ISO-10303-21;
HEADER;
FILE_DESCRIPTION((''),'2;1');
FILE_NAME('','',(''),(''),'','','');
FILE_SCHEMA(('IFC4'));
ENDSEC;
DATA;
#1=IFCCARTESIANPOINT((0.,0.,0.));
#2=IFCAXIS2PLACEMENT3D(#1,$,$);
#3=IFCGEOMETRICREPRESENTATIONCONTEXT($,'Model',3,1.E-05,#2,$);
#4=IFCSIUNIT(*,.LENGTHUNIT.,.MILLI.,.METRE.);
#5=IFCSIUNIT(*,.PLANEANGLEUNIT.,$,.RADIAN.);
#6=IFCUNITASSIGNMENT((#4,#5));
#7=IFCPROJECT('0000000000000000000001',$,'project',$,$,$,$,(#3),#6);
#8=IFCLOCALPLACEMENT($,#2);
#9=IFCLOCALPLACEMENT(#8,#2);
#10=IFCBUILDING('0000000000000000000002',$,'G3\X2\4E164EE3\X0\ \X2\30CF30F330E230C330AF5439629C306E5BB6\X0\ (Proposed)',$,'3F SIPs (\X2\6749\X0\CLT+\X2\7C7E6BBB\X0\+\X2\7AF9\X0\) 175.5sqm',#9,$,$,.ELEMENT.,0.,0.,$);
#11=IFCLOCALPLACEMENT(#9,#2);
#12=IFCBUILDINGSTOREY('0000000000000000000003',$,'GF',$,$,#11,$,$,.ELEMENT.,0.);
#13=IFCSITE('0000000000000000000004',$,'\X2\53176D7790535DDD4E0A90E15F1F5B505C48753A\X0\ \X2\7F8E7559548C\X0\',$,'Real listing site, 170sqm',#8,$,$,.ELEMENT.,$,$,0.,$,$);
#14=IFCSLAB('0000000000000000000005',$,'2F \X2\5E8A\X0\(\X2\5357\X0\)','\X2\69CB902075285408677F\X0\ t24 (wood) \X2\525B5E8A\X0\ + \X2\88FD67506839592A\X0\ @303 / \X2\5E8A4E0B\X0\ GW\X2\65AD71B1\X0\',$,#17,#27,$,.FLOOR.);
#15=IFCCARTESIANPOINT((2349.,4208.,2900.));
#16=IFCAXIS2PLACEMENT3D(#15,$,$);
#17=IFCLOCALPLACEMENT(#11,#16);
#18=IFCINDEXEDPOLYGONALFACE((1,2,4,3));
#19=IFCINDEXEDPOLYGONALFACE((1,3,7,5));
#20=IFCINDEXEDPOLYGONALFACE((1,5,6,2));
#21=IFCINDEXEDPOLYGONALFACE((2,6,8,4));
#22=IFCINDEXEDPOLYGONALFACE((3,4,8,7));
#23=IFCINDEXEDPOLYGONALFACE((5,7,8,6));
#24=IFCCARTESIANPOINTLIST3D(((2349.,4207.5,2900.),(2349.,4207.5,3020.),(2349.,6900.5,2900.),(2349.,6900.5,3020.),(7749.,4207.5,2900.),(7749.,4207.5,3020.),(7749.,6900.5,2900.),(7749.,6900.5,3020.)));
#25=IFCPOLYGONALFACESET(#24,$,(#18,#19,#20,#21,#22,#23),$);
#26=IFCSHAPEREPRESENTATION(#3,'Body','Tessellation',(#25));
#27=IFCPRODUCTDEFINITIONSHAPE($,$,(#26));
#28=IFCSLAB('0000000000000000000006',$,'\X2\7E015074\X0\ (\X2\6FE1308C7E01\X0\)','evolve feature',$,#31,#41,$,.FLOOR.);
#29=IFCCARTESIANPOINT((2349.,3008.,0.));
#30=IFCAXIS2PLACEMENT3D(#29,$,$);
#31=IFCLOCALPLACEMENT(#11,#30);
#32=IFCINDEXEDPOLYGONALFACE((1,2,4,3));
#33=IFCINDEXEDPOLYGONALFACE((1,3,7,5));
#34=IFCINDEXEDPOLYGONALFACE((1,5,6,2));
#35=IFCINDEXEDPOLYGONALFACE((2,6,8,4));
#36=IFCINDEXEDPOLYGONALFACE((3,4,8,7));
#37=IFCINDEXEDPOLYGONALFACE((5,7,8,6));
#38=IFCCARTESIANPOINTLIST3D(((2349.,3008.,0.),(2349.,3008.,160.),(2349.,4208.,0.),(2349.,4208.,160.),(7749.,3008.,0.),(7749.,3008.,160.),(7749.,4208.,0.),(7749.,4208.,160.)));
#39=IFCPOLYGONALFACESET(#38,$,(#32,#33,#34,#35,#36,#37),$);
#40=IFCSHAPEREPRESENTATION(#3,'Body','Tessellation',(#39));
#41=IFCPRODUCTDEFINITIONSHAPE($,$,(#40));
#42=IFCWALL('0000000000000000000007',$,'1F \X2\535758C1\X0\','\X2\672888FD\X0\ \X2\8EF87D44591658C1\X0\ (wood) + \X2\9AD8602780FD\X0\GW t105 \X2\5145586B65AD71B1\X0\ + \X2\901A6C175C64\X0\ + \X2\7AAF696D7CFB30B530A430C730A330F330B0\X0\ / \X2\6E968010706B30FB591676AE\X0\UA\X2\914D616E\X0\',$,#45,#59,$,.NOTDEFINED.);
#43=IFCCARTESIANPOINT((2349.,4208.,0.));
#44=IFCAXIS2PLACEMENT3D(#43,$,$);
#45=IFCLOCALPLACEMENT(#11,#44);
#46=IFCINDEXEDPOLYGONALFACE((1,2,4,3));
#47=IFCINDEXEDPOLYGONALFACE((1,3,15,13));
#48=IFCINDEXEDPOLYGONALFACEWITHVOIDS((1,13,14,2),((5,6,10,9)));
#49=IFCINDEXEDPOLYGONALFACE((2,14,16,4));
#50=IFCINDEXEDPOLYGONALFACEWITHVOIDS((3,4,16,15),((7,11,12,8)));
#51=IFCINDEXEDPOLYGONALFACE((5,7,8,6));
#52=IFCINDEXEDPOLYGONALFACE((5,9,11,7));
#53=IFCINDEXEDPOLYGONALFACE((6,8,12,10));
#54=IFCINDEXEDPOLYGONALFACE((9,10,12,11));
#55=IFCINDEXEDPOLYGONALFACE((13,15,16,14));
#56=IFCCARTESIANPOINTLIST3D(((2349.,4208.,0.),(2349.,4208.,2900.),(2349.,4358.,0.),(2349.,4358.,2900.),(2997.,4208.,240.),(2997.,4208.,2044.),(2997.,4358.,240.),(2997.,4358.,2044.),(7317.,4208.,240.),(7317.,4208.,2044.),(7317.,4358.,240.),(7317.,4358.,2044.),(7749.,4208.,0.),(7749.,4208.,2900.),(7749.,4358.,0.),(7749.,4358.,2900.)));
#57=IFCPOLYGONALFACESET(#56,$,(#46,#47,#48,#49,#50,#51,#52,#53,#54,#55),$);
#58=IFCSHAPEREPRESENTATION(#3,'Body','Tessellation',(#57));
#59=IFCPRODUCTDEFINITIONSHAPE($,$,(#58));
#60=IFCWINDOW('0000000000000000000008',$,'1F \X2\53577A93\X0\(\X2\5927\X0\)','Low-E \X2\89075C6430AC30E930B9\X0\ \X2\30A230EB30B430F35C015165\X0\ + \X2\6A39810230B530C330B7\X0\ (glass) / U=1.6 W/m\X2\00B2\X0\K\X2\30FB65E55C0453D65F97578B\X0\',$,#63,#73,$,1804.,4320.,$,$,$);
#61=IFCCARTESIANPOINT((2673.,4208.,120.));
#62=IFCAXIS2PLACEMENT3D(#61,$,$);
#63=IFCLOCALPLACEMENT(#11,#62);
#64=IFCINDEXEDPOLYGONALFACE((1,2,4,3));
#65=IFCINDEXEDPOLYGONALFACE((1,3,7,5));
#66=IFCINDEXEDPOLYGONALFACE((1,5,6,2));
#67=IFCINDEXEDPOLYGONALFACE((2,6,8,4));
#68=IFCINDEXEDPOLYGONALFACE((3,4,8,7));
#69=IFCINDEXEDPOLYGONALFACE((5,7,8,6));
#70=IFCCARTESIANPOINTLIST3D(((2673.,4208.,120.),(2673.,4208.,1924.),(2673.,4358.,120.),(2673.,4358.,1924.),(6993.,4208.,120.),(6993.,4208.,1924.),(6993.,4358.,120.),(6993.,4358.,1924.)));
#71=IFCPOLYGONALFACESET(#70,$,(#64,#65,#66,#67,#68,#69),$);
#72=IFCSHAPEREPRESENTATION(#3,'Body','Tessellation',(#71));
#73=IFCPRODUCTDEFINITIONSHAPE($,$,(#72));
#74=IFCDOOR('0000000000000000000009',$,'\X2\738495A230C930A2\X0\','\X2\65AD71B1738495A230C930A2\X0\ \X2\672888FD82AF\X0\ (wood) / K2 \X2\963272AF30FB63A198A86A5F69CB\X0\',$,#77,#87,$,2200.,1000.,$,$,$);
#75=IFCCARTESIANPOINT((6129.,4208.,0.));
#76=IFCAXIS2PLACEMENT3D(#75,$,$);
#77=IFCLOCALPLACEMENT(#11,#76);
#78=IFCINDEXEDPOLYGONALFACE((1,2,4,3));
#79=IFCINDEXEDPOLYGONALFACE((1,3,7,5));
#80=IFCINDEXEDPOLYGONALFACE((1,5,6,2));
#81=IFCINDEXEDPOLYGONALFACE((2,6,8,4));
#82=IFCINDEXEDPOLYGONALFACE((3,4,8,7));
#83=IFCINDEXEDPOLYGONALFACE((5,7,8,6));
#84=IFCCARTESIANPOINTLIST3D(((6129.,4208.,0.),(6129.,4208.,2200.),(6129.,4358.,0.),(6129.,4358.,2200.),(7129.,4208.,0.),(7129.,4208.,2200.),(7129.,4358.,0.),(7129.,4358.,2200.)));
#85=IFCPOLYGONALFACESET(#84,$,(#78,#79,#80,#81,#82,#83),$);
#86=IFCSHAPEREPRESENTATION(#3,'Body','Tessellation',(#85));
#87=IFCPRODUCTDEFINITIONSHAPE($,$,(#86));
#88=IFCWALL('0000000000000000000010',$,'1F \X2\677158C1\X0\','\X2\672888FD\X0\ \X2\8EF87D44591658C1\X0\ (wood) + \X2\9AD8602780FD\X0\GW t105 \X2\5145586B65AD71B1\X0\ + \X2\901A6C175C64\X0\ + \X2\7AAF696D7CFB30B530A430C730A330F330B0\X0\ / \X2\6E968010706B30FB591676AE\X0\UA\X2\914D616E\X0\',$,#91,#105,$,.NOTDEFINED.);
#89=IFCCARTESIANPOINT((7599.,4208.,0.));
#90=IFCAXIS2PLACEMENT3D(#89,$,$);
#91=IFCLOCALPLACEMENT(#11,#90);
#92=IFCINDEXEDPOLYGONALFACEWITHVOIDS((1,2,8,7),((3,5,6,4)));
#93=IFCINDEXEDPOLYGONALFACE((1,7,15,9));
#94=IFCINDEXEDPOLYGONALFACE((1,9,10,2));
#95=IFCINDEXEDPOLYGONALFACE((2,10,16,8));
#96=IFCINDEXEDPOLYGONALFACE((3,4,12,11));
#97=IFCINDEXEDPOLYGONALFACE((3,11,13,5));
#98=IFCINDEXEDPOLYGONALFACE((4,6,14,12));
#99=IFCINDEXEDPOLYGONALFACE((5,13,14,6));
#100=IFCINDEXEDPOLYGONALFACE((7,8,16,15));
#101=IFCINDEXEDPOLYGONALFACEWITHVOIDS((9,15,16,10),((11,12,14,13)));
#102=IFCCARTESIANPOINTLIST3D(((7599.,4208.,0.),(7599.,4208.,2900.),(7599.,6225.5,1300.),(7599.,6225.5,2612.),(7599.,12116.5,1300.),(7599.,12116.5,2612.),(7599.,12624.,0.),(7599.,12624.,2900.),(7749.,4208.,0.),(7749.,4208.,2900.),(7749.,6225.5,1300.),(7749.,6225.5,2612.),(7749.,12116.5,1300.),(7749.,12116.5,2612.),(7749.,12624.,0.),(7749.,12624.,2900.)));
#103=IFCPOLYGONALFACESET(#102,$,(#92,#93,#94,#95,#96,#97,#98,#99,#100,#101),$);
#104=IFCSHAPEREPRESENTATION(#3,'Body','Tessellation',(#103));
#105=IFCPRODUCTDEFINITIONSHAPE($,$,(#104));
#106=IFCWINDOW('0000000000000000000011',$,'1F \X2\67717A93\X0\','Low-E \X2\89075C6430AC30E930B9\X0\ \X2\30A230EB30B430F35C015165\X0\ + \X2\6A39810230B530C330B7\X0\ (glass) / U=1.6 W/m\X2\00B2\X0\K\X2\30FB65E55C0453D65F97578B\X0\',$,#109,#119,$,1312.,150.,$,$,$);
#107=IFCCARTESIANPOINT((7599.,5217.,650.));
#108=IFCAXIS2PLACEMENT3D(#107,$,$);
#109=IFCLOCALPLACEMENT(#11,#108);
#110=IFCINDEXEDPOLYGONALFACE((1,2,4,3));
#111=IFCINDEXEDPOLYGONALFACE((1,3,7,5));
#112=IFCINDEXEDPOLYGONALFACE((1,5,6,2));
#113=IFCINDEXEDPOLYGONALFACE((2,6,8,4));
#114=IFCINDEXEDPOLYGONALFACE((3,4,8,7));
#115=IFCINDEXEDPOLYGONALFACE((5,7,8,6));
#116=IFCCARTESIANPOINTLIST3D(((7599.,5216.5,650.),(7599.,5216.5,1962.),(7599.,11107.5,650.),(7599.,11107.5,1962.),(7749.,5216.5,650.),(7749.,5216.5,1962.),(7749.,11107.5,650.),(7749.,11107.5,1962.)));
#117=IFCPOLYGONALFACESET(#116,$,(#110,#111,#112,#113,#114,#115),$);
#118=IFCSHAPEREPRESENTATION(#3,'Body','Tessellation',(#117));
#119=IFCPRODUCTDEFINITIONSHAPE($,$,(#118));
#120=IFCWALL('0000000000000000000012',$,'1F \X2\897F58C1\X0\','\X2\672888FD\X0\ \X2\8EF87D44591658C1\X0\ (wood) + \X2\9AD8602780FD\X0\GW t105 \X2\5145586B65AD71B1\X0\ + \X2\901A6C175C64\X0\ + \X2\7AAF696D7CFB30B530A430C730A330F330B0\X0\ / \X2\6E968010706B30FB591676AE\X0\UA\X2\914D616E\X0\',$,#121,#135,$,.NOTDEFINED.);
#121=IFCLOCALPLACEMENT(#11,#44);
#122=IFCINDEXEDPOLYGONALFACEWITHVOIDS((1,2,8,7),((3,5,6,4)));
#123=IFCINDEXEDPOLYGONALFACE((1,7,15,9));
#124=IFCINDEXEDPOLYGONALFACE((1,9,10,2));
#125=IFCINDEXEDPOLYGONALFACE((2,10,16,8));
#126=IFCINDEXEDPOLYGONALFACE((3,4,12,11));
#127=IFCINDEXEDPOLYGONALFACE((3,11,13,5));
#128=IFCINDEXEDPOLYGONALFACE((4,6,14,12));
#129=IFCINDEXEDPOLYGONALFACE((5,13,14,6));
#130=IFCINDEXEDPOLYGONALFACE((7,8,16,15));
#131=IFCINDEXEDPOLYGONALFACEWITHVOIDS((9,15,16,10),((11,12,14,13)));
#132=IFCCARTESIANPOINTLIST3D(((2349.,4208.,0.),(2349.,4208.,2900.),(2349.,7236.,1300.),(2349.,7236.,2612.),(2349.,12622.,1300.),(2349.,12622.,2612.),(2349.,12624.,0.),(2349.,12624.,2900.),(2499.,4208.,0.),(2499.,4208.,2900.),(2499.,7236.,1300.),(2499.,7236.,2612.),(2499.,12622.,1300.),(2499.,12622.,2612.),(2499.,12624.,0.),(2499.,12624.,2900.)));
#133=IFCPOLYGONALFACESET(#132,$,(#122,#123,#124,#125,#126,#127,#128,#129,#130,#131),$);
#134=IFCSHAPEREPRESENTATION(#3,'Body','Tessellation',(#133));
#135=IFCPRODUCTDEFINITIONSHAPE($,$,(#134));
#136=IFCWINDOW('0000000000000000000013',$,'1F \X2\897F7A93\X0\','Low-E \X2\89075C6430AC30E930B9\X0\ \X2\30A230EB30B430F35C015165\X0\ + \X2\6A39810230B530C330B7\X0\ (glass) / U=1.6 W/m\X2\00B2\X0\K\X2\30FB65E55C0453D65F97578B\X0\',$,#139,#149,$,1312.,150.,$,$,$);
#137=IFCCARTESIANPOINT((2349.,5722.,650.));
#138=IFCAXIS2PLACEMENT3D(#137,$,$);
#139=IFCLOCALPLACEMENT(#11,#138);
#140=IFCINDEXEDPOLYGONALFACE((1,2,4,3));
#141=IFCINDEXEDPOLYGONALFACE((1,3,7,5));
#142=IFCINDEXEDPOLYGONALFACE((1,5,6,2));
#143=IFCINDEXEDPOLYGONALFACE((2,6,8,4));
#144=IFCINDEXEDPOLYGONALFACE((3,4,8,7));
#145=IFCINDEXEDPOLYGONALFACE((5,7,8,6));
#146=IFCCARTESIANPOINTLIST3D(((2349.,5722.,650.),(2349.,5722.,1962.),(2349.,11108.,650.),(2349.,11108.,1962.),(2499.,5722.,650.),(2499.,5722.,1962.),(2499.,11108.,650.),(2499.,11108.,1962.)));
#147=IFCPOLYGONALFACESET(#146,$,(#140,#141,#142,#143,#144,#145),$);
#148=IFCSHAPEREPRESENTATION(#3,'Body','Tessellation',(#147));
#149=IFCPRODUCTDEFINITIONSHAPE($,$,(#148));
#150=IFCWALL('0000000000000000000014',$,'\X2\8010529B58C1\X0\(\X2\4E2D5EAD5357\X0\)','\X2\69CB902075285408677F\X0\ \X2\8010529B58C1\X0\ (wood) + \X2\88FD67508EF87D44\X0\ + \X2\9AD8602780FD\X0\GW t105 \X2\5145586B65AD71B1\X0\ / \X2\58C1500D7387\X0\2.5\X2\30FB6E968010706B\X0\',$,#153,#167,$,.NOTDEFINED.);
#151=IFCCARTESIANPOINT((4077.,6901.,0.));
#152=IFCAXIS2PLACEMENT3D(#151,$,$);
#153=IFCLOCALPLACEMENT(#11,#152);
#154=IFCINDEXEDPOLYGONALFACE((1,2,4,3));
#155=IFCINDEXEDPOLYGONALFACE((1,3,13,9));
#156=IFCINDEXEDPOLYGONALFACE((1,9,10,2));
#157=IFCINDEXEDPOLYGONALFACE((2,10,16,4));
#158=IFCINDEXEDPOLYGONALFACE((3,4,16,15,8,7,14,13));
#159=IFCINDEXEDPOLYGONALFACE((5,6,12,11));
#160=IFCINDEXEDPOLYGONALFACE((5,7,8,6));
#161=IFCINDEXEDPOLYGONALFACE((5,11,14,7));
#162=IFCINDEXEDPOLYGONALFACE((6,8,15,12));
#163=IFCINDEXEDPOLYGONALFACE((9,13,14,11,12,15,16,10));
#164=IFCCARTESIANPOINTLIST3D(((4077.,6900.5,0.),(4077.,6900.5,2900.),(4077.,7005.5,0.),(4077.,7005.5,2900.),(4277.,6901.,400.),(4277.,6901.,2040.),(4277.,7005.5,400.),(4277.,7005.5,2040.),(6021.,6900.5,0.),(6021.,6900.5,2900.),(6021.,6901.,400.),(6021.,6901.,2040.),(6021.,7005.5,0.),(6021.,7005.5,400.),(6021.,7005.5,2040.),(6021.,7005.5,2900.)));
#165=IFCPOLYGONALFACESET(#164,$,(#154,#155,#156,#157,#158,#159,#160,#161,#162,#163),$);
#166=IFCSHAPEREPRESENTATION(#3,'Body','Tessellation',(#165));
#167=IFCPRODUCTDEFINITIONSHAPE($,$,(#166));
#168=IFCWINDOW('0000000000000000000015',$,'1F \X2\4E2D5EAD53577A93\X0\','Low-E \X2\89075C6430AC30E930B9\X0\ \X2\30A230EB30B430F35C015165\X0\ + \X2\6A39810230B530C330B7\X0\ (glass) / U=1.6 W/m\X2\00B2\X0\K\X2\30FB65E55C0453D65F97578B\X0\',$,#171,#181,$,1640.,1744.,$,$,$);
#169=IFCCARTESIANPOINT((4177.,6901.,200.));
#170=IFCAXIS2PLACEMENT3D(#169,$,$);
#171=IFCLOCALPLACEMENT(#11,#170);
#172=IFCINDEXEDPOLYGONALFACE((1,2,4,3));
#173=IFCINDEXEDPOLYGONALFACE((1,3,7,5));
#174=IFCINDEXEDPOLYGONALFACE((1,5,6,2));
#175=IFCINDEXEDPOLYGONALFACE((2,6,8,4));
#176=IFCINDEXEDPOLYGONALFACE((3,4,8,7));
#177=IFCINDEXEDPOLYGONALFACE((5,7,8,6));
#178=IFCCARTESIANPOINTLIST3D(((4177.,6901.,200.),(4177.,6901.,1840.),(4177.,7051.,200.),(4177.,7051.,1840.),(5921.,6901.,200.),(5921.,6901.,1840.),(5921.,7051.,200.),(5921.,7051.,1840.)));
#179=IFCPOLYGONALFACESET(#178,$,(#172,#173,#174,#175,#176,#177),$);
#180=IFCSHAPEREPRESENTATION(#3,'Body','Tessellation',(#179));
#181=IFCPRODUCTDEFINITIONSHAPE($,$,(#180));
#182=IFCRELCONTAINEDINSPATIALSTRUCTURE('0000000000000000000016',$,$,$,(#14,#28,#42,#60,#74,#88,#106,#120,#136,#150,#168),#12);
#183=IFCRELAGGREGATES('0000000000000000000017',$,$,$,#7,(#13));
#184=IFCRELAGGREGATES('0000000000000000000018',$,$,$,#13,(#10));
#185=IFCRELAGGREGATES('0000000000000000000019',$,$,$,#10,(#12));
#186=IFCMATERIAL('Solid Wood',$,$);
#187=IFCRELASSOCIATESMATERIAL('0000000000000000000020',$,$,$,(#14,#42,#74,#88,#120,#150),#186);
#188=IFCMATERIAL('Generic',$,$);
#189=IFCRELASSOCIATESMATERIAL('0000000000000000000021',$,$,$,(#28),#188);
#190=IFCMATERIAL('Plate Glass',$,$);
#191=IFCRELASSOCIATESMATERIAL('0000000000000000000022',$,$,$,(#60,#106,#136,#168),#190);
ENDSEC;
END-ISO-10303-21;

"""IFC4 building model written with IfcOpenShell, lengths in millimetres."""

from ifc_helpers import new_model, si_unit, frame, frame_2d, origin, place, context, project, spatial, rectangle, extrude, material, element, fill, save


model = new_model("IFC4")

# Units and contexts
model_context = context("Model", 3, precision=1e-05, world=origin())
ifc_project = project(units=[si_unit("LENGTHUNIT", "METRE", prefix="MILLI"), si_unit("PLANEANGLEUNIT", "RADIAN")], contexts=[model_context])

# Site, building, storey
site_placement = place(None, origin())
site = spatial("IfcSite", under=ifc_project, at=site_placement, Name="北海道川上郡弟子屈町 美留和", ObjectType="Real listing site, 170sqm", CompositionType="ELEMENT", RefElevation=0.0)
building_placement = place(site_placement, origin())
building = spatial("IfcBuilding", under=site, at=building_placement, Name="G3世代 ハンモック吹抜の家 (Proposed)", ObjectType="3F SIPs (杉CLT+籾殻+竹) 175.5sqm", CompositionType="ELEMENT", ElevationOfRefHeight=0.0, ElevationOfTerrain=0.0)
storey_placement = place(building_placement, origin())
storey = spatial("IfcBuildingStorey", under=building, at=storey_placement, Name="GF", CompositionType="ELEMENT", Elevation=0.0)

# Slabs
ifc_material_1 = material(Name="Solid Wood")
slab_1_placement = place(storey_placement, frame((2349.0, 4208.0, 2900.0)))
element("IfcSlab", 1, at=slab_1_placement, inside=storey, material=ifc_material_1, Name="2F 床(南)", Description="構造用合板 t24 (wood) 剛床 + 製材根太 @303 / 床下 GW断熱", PredefinedType="FLOOR", context=model_context, shape_type="SweptSolid", body=[
    extrude(rectangle(XDim=5400.0, YDim=2693.0, at=frame_2d((2700.0, 1346.0))), frame((2349.0, 4208.0, 2900.0)), (0.0, 0.0, 1.0), 120.0),
])
ifc_material_2 = material(Name="Generic")
slab_2_placement = place(storey_placement, frame((2349.0, 3008.0, 0.0)))
element("IfcSlab", 2, at=slab_2_placement, inside=storey, material=ifc_material_2, Name="縁側 (濡れ縁)", Description="evolve feature", PredefinedType="FLOOR", context=model_context, shape_type="SweptSolid", body=[
    extrude(rectangle(XDim=5400.0, YDim=1200.0, at=frame_2d((2700.0, 600.0))), frame((2349.0, 3008.0, 0.0)), (0.0, 0.0, 1.0), 160.0),
])

# Wall, openings, window, door
wall_1_placement = place(storey_placement, frame((2349.0, 4208.0, 0.0)))
wall_1 = element("IfcWall", 3, at=wall_1_placement, inside=storey, material=ifc_material_1, Name="1F 南壁", Description="木製 軸組外壁 (wood) + 高性能GW t105 充填断熱 + 通気層 + 窯業系サイディング / 準耐火・外皮UA配慮", PredefinedType="NOTDEFINED", context=model_context, shape_type="SweptSolid", body=[
    extrude(rectangle(XDim=5400.0, YDim=150.0, at=frame_2d((2700.0, 75.0))), frame((2349.0, 4208.0, 0.0)), (0.0, 0.0, 1.0), 2900.0),
])
opening_1_placement = place(storey_placement, frame((2673.0, 4208.0, 120.0)))
opening_1 = element("IfcOpeningElement", 4, at=opening_1_placement, cuts=wall_1, PredefinedType="NOTDEFINED", context=model_context, shape_type="SweptSolid", body=[
    extrude(rectangle(XDim=4320.0, YDim=150.0, at=frame_2d((2160.0, 75.0))), frame((2673.0, 4208.0, 120.0)), (0.0, 0.0, 1.0), 1804.0),
])
opening_2_placement = place(storey_placement, frame((6129.0, 4208.0, 0.0)))
opening_2 = element("IfcOpeningElement", 5, at=opening_2_placement, cuts=wall_1, PredefinedType="NOTDEFINED", context=model_context, shape_type="SweptSolid", body=[
    extrude(rectangle(XDim=1000.0, YDim=150.0, at=frame_2d((500.0, 75.0))), frame((6129.0, 4208.0, 0.0)), (0.0, 0.0, 1.0), 2200.0),
])
ifc_material_3 = material(Name="Plate Glass")
window_1_placement = place(storey_placement, frame((2673.0, 4208.0, 120.0)))
window_1 = element("IfcWindow", 6, at=window_1_placement, inside=storey, material=ifc_material_3, Name="1F 南窓(大)", Description="Low-E 複層ガラス アルゴン封入 + 樹脂サッシ (glass) / U=1.6 W/m²K・日射取得型", OverallHeight=1804.0, OverallWidth=4320.0, context=model_context, shape_type="SweptSolid", body=[
    extrude(rectangle(XDim=4320.0, YDim=150.0, at=frame_2d((2160.0, 75.0))), frame((2673.0, 4208.0, 120.0)), (0.0, 0.0, 1.0), 1804.0),
])
fill(opening_1, window_1)
door_placement = place(storey_placement, frame((6129.0, 4208.0, 0.0)))
door = element("IfcDoor", 7, at=door_placement, inside=storey, material=ifc_material_1, Name="玄関ドア", Description="断熱玄関ドア 木製芯 (wood) / K2 防犯・採風機構", OverallHeight=2200.0, OverallWidth=1000.0, context=model_context, shape_type="SweptSolid", body=[
    extrude(rectangle(XDim=1000.0, YDim=150.0, at=frame_2d((500.0, 75.0))), frame((6129.0, 4208.0, 0.0)), (0.0, 0.0, 1.0), 2200.0),
])
fill(opening_2, door)

# Walls, openings, windows
wall_2_placement = place(storey_placement, frame((7599.0, 4208.0, 0.0)))
wall_2 = element("IfcWall", 8, at=wall_2_placement, inside=storey, material=ifc_material_1, Name="1F 東壁", Description="木製 軸組外壁 (wood) + 高性能GW t105 充填断熱 + 通気層 + 窯業系サイディング / 準耐火・外皮UA配慮", PredefinedType="NOTDEFINED", context=model_context, shape_type="SweptSolid", body=[
    extrude(rectangle(XDim=150.0, YDim=8416.0, at=frame_2d((75.0, 4208.0))), frame((7599.0, 4208.0, 0.0)), (0.0, 0.0, 1.0), 2900.0),
])
opening_3_placement = place(storey_placement, frame((7599.0, 5217.0, 650.0)))
opening_3 = element("IfcOpeningElement", 9, at=opening_3_placement, cuts=wall_2, PredefinedType="NOTDEFINED", context=model_context, shape_type="SweptSolid", body=[
    extrude(rectangle(XDim=150.0, YDim=5891.0, at=frame_2d((75.0, 2945.0))), frame((7599.0, 5217.0, 650.0)), (0.0, 0.0, 1.0), 1312.0),
])
window_2_placement = place(storey_placement, frame((7599.0, 5217.0, 650.0)))
window_2 = element("IfcWindow", 10, at=window_2_placement, inside=storey, material=ifc_material_3, Name="1F 東窓", Description="Low-E 複層ガラス アルゴン封入 + 樹脂サッシ (glass) / U=1.6 W/m²K・日射取得型", OverallHeight=1312.0, OverallWidth=150.0, context=model_context, shape_type="SweptSolid", body=[
    extrude(rectangle(XDim=150.0, YDim=5891.0, at=frame_2d((75.0, 2945.0))), frame((7599.0, 5217.0, 650.0)), (0.0, 0.0, 1.0), 1312.0),
])
fill(opening_3, window_2)
wall_3_placement = place(storey_placement, frame((2349.0, 4208.0, 0.0)))
wall_3 = element("IfcWall", 11, at=wall_3_placement, inside=storey, material=ifc_material_1, Name="1F 西壁", Description="木製 軸組外壁 (wood) + 高性能GW t105 充填断熱 + 通気層 + 窯業系サイディング / 準耐火・外皮UA配慮", PredefinedType="NOTDEFINED", context=model_context, shape_type="SweptSolid", body=[
    extrude(rectangle(XDim=150.0, YDim=8416.0, at=frame_2d((75.0, 4208.0))), frame((2349.0, 4208.0, 0.0)), (0.0, 0.0, 1.0), 2900.0),
])
opening_4_placement = place(storey_placement, frame((2349.0, 5722.0, 650.0)))
opening_4 = element("IfcOpeningElement", 12, at=opening_4_placement, cuts=wall_3, PredefinedType="NOTDEFINED", context=model_context, shape_type="SweptSolid", body=[
    extrude(rectangle(XDim=150.0, YDim=5386.0, at=frame_2d((75.0, 2693.0))), frame((2349.0, 5722.0, 650.0)), (0.0, 0.0, 1.0), 1312.0),
])
window_3_placement = place(storey_placement, frame((2349.0, 5722.0, 650.0)))
window_3 = element("IfcWindow", 13, at=window_3_placement, inside=storey, material=ifc_material_3, Name="1F 西窓", Description="Low-E 複層ガラス アルゴン封入 + 樹脂サッシ (glass) / U=1.6 W/m²K・日射取得型", OverallHeight=1312.0, OverallWidth=150.0, context=model_context, shape_type="SweptSolid", body=[
    extrude(rectangle(XDim=150.0, YDim=5386.0, at=frame_2d((75.0, 2693.0))), frame((2349.0, 5722.0, 650.0)), (0.0, 0.0, 1.0), 1312.0),
])
fill(opening_4, window_3)
wall_4_placement = place(storey_placement, frame((4077.0, 6901.0, 0.0)))
wall_4 = element("IfcWall", 14, at=wall_4_placement, inside=storey, material=ifc_material_1, Name="耐力壁(中庭南)", Description="構造用合板 耐力壁 (wood) + 製材軸組 + 高性能GW t105 充填断熱 / 壁倍率2.5・準耐火", PredefinedType="NOTDEFINED", context=model_context, shape_type="SweptSolid", body=[
    extrude(rectangle(XDim=1944.0, YDim=105.0, at=frame_2d((972.0, 52.0))), frame((4077.0, 6901.0, 0.0)), (0.0, 0.0, 1.0), 2900.0),
])
opening_5_placement = place(storey_placement, frame((4177.0, 6901.0, 200.0)))
opening_5 = element("IfcOpeningElement", 15, at=opening_5_placement, cuts=wall_4, PredefinedType="NOTDEFINED", context=model_context, shape_type="SweptSolid", body=[
    extrude(rectangle(XDim=1744.0, YDim=150.0, at=frame_2d((872.0, 75.0))), frame((4177.0, 6901.0, 200.0)), (0.0, 0.0, 1.0), 1640.0),
])
window_4_placement = place(storey_placement, frame((4177.0, 6901.0, 200.0)))
window_4 = element("IfcWindow", 16, at=window_4_placement, inside=storey, material=ifc_material_3, Name="1F 中庭南窓", Description="Low-E 複層ガラス アルゴン封入 + 樹脂サッシ (glass) / U=1.6 W/m²K・日射取得型", OverallHeight=1640.0, OverallWidth=1744.0, context=model_context, shape_type="SweptSolid", body=[
    extrude(rectangle(XDim=1744.0, YDim=150.0, at=frame_2d((872.0, 75.0))), frame((4177.0, 6901.0, 200.0)), (0.0, 0.0, 1.0), 1640.0),
])
fill(opening_5, window_4)

save(model, "model.ifc")
